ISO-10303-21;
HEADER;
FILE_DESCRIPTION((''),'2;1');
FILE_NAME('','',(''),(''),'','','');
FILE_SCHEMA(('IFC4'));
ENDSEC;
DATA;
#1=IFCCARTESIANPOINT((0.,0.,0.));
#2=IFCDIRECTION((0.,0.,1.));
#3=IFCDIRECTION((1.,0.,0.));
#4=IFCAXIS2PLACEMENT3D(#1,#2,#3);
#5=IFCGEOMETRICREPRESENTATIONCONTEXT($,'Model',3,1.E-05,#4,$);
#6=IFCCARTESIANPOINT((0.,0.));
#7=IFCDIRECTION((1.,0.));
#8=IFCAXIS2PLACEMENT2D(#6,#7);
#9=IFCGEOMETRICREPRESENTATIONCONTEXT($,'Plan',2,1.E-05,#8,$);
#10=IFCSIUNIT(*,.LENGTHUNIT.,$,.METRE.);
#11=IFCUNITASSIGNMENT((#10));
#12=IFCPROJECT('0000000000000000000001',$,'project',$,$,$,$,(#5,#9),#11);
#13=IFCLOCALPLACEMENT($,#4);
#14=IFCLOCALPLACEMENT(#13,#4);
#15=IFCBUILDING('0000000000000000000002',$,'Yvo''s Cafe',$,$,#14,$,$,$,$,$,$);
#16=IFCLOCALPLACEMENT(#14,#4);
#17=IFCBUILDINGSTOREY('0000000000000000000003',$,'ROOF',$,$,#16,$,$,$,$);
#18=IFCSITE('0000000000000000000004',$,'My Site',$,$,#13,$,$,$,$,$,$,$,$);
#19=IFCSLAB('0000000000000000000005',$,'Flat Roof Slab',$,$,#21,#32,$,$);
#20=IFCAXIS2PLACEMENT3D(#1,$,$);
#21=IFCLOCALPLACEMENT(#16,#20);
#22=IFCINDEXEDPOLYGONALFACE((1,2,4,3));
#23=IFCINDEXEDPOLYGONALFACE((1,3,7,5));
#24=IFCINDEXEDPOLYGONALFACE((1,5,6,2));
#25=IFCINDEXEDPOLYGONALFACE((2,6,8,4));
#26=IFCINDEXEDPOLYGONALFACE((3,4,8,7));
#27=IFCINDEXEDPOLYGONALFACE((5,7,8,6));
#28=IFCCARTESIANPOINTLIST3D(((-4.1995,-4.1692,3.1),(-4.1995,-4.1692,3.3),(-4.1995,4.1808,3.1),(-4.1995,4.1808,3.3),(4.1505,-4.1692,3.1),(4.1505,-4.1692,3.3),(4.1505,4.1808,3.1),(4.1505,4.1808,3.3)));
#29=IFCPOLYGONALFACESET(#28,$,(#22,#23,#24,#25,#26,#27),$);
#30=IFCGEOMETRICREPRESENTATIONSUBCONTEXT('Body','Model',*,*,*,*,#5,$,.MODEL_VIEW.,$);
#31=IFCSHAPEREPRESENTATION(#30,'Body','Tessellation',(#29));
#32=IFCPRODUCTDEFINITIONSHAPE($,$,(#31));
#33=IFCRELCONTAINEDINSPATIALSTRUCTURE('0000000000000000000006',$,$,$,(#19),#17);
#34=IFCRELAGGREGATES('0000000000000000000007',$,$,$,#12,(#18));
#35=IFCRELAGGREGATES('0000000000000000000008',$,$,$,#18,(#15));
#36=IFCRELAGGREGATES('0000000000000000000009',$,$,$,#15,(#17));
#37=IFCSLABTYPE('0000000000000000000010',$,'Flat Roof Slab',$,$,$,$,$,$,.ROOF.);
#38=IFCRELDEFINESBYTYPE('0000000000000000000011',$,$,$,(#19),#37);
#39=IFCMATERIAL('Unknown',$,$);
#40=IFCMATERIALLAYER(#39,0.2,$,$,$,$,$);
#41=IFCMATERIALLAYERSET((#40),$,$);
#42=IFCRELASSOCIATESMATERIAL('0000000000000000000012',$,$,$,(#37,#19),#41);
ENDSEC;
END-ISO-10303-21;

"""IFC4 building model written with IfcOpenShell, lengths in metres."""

from ifc_helpers import new_model, si_unit, frame, origin_with_axes, origin_2d_with_axis, place, context, subcontext, project, spatial, indexed_curve, outline, extrude, material, layer, layer_set, layer_usage, type_object, element, save


model = new_model("IFC4")

# Units and contexts
model_context = context("Model", 3, precision=1e-05, world=origin_with_axes())
plan_context = context("Plan", 2, precision=1e-05, world=origin_2d_with_axis())
body_context = subcontext(model_context, "Body", "Model", "MODEL_VIEW")
ifc_project = project(units=[si_unit("LENGTHUNIT", "METRE")], contexts=[model_context, plan_context])

# Site, building, storey
site_placement = place(None, origin_with_axes())
site = spatial("IfcSite", under=ifc_project, at=site_placement, Name="My Site")
building_placement = place(site_placement, origin_with_axes())
building = spatial("IfcBuilding", under=site, at=building_placement, Name="Yvo's Cafe")
storey_placement = place(building_placement, origin_with_axes())
storey = spatial("IfcBuildingStorey", under=building, at=storey_placement, Name="ROOF")

# Slab
ifc_material = material(Name="Unknown")
ifc_layer = layer(ifc_material, 0.2)
ifc_layer_set = layer_set([ifc_layer])
ifc_layer_usage = layer_usage(ifc_layer_set, "AXIS3", "POSITIVE", -0.2)
slab_type = type_object("IfcSlabType", Name="Flat Roof Slab", PredefinedType="ROOF", material=ifc_layer_set)
slab_placement = place(storey_placement, frame((4.1505, 4.1808, 3.3), z_axis=(0.0, 0.0, 1.0), x_axis=(1.0, 0.0, 0.0)))
element("IfcSlab", 1, at=slab_placement, inside=storey, type_object=slab_type, material=ifc_layer_usage, Name="Flat Roof Slab", context=body_context, shape_type="SweptSolid", body=[
    extrude(outline(indexed_curve([(0.0, 0.0), (0.0, -8.35), (-8.35, -8.35), (-8.35, 0.0), (0.0, 0.0)])), frame((0.0, 0.0, -0.2), z_axis=(0.0, 0.0, 1.0), x_axis=(1.0, 0.0, 0.0)), (0.0, 0.0, 1.0), 0.2),
])

save(model, "model.ifc")
